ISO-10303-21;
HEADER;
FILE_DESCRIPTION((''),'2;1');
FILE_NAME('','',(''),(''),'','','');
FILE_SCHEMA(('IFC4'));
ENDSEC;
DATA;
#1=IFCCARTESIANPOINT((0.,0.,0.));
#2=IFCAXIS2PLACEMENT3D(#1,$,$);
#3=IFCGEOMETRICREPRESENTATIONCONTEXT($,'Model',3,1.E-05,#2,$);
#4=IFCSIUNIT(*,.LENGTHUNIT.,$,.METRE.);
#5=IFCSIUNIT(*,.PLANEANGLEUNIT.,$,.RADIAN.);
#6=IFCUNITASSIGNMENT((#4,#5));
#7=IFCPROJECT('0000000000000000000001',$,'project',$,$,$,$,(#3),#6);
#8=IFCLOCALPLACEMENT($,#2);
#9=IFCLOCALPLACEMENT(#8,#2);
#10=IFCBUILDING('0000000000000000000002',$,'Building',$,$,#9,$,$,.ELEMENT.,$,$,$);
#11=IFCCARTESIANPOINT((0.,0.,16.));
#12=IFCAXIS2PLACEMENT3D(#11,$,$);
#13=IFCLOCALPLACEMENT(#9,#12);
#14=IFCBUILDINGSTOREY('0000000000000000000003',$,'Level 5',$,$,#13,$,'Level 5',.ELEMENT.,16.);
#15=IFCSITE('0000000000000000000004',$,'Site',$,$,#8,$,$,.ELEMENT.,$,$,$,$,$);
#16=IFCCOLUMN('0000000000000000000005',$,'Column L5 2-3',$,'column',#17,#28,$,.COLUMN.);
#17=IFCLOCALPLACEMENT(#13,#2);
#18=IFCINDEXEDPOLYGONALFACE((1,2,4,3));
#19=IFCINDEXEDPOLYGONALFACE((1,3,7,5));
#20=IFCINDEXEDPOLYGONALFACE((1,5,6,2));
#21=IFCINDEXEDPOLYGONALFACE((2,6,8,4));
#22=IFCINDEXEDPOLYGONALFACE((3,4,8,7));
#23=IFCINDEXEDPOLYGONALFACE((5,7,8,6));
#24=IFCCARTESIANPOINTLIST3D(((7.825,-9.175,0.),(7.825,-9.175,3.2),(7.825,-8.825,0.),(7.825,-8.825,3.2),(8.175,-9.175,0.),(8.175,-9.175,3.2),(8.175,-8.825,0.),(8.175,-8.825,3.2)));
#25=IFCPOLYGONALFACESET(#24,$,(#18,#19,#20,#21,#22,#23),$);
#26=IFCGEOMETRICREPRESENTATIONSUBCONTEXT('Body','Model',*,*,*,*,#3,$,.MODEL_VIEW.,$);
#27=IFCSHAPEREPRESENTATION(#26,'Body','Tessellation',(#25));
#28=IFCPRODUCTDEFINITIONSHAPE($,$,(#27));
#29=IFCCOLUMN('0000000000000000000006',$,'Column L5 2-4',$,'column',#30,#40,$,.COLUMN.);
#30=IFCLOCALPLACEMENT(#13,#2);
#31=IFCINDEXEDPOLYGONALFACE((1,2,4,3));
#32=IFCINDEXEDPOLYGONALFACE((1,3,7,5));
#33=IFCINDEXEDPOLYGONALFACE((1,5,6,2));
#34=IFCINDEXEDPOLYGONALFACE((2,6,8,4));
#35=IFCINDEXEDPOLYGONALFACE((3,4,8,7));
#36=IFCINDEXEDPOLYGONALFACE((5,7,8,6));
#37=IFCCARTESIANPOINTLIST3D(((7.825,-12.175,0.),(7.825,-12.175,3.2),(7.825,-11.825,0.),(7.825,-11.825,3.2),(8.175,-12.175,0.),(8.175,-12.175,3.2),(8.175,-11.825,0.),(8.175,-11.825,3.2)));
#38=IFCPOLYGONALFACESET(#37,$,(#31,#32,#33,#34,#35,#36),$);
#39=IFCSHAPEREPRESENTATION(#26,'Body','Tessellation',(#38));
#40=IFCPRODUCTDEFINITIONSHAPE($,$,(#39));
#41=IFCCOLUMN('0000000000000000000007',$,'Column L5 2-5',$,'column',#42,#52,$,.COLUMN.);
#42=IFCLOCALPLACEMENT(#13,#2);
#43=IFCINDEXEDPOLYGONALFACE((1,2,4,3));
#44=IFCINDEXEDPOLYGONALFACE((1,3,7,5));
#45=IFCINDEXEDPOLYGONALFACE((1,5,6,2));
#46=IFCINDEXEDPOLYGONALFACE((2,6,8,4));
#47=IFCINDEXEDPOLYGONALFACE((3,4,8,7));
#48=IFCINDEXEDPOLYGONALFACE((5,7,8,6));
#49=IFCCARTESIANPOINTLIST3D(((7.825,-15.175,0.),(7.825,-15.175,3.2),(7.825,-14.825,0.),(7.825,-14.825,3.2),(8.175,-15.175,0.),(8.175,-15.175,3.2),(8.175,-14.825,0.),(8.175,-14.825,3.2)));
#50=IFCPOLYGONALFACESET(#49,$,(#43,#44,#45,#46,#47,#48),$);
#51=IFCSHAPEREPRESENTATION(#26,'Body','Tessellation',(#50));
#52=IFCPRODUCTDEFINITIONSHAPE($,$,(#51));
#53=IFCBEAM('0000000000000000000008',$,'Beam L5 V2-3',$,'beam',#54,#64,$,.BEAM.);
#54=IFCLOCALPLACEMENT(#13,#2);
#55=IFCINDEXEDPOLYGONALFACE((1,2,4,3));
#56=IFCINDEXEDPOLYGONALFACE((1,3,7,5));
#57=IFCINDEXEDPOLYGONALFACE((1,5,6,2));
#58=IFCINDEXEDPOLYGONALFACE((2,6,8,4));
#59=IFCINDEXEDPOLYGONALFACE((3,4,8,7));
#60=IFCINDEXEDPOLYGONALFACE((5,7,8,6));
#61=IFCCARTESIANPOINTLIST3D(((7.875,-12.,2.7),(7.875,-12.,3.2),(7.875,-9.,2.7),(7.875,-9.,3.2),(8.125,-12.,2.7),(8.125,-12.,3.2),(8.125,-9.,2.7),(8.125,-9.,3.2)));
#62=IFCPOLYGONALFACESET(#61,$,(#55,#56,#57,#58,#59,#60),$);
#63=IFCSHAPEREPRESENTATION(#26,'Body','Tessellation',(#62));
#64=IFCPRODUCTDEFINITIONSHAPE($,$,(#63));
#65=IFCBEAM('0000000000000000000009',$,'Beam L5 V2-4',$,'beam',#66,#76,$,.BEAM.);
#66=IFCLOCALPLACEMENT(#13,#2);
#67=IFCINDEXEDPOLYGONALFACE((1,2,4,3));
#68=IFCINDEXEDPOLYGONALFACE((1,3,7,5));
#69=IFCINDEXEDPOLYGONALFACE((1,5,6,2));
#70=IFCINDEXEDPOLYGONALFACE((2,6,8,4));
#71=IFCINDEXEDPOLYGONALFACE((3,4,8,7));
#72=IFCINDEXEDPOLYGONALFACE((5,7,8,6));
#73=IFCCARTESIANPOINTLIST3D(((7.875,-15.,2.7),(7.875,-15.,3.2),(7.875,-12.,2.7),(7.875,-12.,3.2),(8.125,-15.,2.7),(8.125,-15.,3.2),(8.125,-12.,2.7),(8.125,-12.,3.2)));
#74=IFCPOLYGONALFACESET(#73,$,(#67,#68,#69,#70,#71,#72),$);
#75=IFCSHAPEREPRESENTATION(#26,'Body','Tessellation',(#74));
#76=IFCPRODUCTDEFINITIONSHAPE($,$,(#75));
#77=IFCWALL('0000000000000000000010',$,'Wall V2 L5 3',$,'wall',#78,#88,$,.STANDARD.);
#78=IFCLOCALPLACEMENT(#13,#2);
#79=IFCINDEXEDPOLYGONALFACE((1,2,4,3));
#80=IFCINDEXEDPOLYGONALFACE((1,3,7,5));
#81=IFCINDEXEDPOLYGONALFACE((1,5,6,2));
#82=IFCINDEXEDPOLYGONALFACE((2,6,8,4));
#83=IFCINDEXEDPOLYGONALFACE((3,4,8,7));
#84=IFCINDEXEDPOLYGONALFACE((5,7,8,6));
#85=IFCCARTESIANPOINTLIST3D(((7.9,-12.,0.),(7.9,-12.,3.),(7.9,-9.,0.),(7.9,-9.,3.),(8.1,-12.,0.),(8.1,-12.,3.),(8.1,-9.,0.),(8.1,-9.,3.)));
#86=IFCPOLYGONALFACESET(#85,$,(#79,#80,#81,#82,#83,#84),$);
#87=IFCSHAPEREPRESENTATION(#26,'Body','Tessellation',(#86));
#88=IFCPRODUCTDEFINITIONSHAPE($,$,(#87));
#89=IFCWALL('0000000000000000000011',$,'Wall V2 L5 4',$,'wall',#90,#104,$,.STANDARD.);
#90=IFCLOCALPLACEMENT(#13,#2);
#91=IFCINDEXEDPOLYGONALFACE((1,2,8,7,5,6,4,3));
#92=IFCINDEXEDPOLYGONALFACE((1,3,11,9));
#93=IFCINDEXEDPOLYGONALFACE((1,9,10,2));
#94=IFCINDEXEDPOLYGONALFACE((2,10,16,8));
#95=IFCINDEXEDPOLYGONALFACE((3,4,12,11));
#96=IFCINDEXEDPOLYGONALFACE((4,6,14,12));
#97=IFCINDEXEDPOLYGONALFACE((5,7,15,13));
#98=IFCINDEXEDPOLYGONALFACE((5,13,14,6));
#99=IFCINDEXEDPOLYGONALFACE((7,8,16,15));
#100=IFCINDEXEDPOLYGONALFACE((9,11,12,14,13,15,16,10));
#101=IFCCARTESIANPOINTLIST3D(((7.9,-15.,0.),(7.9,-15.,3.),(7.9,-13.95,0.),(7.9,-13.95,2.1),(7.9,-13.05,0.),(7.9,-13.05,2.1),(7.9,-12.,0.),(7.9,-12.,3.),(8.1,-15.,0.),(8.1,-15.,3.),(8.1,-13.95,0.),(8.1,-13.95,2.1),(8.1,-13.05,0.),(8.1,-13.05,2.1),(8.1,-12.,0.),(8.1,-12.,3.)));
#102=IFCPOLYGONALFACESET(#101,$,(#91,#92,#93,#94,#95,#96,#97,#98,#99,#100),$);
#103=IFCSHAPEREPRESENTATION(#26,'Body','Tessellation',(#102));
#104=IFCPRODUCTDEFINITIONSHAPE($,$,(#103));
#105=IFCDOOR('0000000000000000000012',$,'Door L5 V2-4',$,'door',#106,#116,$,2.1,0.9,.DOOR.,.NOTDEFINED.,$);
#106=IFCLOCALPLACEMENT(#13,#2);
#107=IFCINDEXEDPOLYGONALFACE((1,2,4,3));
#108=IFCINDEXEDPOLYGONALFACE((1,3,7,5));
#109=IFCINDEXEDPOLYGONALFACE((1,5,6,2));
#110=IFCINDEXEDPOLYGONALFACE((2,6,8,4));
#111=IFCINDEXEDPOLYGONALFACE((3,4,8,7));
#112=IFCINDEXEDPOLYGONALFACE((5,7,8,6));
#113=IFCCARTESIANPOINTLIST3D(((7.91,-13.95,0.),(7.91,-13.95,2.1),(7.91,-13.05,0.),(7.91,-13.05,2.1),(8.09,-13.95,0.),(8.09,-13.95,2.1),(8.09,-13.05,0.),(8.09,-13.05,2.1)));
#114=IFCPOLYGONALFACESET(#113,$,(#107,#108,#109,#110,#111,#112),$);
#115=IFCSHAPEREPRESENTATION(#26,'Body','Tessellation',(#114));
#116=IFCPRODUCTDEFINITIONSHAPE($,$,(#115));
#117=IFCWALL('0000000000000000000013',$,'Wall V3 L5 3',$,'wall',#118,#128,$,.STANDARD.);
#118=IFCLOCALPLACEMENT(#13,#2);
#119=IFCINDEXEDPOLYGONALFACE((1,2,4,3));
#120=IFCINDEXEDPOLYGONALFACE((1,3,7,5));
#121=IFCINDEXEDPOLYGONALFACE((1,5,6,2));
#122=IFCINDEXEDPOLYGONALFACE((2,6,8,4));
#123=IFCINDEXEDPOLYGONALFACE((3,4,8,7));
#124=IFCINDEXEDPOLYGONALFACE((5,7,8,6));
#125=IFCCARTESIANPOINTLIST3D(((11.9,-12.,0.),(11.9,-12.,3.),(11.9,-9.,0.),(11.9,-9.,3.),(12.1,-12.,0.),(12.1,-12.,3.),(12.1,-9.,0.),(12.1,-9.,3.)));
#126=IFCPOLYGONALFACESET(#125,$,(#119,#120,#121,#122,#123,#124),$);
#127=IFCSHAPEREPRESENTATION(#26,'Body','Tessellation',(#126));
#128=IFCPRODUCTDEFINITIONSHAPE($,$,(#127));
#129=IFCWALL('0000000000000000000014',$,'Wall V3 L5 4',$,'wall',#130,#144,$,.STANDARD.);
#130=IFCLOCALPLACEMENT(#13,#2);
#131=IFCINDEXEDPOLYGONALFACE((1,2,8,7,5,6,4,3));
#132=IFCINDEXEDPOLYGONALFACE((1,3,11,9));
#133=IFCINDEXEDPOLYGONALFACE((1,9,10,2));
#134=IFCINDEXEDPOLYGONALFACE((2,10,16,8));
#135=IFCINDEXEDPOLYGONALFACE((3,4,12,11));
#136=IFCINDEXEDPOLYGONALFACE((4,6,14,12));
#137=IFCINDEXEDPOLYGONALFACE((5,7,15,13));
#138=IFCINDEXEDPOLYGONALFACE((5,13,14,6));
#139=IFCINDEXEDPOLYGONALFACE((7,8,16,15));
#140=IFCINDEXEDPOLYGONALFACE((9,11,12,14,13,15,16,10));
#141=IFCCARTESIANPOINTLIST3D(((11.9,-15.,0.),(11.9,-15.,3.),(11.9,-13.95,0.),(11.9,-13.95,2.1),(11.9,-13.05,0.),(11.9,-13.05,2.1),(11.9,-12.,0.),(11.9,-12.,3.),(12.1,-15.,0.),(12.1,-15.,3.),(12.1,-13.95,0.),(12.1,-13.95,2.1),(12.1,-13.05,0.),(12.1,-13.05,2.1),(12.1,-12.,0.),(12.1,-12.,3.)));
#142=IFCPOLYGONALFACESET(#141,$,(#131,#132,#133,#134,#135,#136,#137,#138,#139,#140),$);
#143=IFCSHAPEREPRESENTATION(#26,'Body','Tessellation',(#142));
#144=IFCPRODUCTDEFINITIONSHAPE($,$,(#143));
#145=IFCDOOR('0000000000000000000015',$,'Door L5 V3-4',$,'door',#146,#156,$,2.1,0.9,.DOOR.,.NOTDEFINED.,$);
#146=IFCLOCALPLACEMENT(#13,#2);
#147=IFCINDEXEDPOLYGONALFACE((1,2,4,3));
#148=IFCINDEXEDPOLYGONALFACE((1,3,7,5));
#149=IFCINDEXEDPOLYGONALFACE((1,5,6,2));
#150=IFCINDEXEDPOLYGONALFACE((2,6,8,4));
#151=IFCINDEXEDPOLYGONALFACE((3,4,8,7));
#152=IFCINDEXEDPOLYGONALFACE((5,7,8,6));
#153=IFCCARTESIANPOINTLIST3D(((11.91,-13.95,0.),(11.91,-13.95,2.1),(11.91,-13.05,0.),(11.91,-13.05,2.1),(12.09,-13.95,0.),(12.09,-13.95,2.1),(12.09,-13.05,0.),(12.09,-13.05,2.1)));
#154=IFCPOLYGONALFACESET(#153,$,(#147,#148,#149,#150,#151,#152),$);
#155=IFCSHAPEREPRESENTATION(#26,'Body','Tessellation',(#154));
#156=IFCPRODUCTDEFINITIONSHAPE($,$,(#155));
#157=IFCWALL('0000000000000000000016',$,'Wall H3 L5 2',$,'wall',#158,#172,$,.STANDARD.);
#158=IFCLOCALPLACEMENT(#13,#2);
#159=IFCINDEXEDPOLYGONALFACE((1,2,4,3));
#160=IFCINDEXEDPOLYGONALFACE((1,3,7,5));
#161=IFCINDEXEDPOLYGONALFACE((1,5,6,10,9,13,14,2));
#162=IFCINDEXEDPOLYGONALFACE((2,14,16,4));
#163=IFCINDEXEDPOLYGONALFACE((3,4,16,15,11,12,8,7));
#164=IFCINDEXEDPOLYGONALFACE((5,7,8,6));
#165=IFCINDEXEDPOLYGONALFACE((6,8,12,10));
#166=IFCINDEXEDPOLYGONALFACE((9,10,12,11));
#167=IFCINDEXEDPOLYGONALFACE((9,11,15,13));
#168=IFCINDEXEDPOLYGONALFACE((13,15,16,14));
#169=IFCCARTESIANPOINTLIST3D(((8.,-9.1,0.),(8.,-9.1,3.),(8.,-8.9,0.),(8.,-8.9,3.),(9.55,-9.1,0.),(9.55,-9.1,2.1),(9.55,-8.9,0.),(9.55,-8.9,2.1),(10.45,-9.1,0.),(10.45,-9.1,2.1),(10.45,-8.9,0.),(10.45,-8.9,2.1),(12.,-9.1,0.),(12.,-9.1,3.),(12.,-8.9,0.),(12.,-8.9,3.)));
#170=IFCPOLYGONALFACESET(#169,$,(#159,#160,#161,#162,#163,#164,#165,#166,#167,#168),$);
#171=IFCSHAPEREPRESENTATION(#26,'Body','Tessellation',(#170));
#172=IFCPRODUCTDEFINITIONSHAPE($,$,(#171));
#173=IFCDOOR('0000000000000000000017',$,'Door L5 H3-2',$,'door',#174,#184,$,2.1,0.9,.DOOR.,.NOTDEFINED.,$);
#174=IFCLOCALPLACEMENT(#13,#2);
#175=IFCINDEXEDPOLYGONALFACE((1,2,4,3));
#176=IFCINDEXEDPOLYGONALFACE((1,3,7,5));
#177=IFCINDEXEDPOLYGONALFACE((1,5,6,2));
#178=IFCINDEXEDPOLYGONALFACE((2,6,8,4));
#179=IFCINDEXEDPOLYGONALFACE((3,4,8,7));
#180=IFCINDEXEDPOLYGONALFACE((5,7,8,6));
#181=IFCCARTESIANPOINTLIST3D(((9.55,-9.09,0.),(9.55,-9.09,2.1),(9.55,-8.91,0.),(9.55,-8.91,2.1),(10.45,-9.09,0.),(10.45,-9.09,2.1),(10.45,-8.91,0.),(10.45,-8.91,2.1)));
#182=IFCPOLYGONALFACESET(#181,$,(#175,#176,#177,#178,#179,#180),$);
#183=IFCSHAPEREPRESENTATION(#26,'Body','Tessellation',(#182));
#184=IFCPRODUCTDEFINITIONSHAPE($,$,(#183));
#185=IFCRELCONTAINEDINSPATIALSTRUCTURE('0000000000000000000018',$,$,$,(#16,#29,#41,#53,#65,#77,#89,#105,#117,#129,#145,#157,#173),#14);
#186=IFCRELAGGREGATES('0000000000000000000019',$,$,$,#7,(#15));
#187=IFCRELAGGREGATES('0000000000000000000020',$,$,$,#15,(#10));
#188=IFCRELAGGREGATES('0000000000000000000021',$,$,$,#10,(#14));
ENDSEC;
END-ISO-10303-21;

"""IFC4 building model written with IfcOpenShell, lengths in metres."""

from ifc_helpers import new_model, si_unit, frame, frame_2d, origin, origin_2d, place, context, subcontext, project, spatial, rectangle, extrude, element, fill, save


model = new_model("IFC4")

# Units and contexts
model_context = context("Model", 3, precision=1e-05, world=origin())
body_context = subcontext(model_context, "Body", "Model", "MODEL_VIEW")
ifc_project = project(units=[si_unit("LENGTHUNIT", "METRE"), si_unit("PLANEANGLEUNIT", "RADIAN")], contexts=[model_context])

# Site, building, storey
site_placement = place(None, origin())
site = spatial("IfcSite", under=ifc_project, at=site_placement, Name="Site", CompositionType="ELEMENT")
building_placement = place(site_placement, origin())
building = spatial("IfcBuilding", under=site, at=building_placement, Name="Building", CompositionType="ELEMENT")
storey_placement = place(building_placement, frame((0.0, 0.0, 16.0)))
storey = spatial("IfcBuildingStorey", under=building, at=storey_placement, Name="Level 5", LongName="Level 5", CompositionType="ELEMENT", Elevation=16.0)

# Columns
for number, where, name in (
    (1, (8.0, -9.0, 0.0), "Column L5 2-3"),
    (2, (8.0, -12.0, 0.0), "Column L5 2-4"),
    (3, (8.0, -15.0, 0.0), "Column L5 2-5"),
):
    element("IfcColumn", number, at=place(storey_placement, frame(where)), inside=storey, Name=name, ObjectType="column", PredefinedType="COLUMN", context=body_context, shape_type="SweptSolid", body=[
        extrude(rectangle(XDim=0.35, YDim=0.35, at=origin_2d()), origin(), (0.0, 0.0, 1.0), 3.2),
    ])

# Beams
for number, where, z_axis, x_axis, name in (
    (4, (8.0, -9.0, 2.95), (0.0, -1.0, 0.0), (0.0, 0.0, 1.0), "Beam L5 V2-3"),
    (5, (8.0, -12.0, 2.95), (0.0, -1.0, 0.0), (0.0, 0.0, 1.0), "Beam L5 V2-4"),
):
    element("IfcBeam", number, at=place(storey_placement, frame(where, z_axis=z_axis, x_axis=x_axis)), inside=storey, Name=name, ObjectType="beam", PredefinedType="BEAM", context=body_context, shape_type="SweptSolid", body=[
        extrude(rectangle(XDim=0.5, YDim=0.25, at=origin_2d()), origin(), (0.0, 0.0, 1.0), 3.0),
    ])

# Wall
wall_1_placement = place(storey_placement, frame((8.0, -9.0, 0.0), z_axis=(0.0, 0.0, 1.0), x_axis=(0.0, -1.0, 0.0)))
element("IfcWall", 6, at=wall_1_placement, inside=storey, Name="Wall V2 L5 3", ObjectType="wall", PredefinedType="STANDARD", context=body_context, shape_type="SweptSolid", body=[
    extrude(rectangle(XDim=3.0, YDim=0.2, at=frame_2d((1.5, 0.0))), origin(), (0.0, 0.0, 1.0), 3.0),
])

# Wall, opening, door
wall_2_placement = place(storey_placement, frame((8.0, -12.0, 0.0), z_axis=(0.0, 0.0, 1.0), x_axis=(0.0, -1.0, 0.0)))
wall_2 = element("IfcWall", 7, at=wall_2_placement, inside=storey, Name="Wall V2 L5 4", ObjectType="wall", PredefinedType="STANDARD", context=body_context, shape_type="SweptSolid", body=[
    extrude(rectangle(XDim=3.0, YDim=0.2, at=frame_2d((1.5, 0.0))), origin(), (0.0, 0.0, 1.0), 3.0),
])
opening_1_placement = place(storey_placement, frame((8.0, -13.5, 0.0), z_axis=(0.0, 0.0, 1.0), x_axis=(0.0, -1.0, 0.0)))
opening_1 = element("IfcOpeningElement", 8, at=opening_1_placement, cuts=wall_2, ObjectType="Opening", PredefinedType="OPENING", context=body_context, shape_type="SweptSolid", body=[
    extrude(rectangle(XDim=0.9, YDim=0.22, at=origin_2d()), origin(), (0.0, 0.0, 1.0), 2.1),
])
door_1_placement = place(storey_placement, frame((8.0, -13.5, 0.0), z_axis=(0.0, 0.0, 1.0), x_axis=(0.0, -1.0, 0.0)))
door_1 = element("IfcDoor", 9, at=door_1_placement, inside=storey, Name="Door L5 V2-4", ObjectType="door", OperationType="NOTDEFINED", OverallHeight=2.1, OverallWidth=0.9, PredefinedType="DOOR", context=body_context, shape_type="SweptSolid", body=[
    extrude(rectangle(XDim=0.9, YDim=0.18, at=origin_2d()), origin(), (0.0, 0.0, 1.0), 2.1),
])
fill(opening_1, door_1)

# Wall
wall_3_placement = place(storey_placement, frame((12.0, -9.0, 0.0), z_axis=(0.0, 0.0, 1.0), x_axis=(0.0, -1.0, 0.0)))
element("IfcWall", 10, at=wall_3_placement, inside=storey, Name="Wall V3 L5 3", ObjectType="wall", PredefinedType="STANDARD", context=body_context, shape_type="SweptSolid", body=[
    extrude(rectangle(XDim=3.0, YDim=0.2, at=frame_2d((1.5, 0.0))), origin(), (0.0, 0.0, 1.0), 3.0),
])

# Walls, openings, doors
wall_4_placement = place(storey_placement, frame((12.0, -12.0, 0.0), z_axis=(0.0, 0.0, 1.0), x_axis=(0.0, -1.0, 0.0)))
wall_4 = element("IfcWall", 11, at=wall_4_placement, inside=storey, Name="Wall V3 L5 4", ObjectType="wall", PredefinedType="STANDARD", context=body_context, shape_type="SweptSolid", body=[
    extrude(rectangle(XDim=3.0, YDim=0.2, at=frame_2d((1.5, 0.0))), origin(), (0.0, 0.0, 1.0), 3.0),
])
opening_2_placement = place(storey_placement, frame((12.0, -13.5, 0.0), z_axis=(0.0, 0.0, 1.0), x_axis=(0.0, -1.0, 0.0)))
opening_2 = element("IfcOpeningElement", 12, at=opening_2_placement, cuts=wall_4, ObjectType="Opening", PredefinedType="OPENING", context=body_context, shape_type="SweptSolid", body=[
    extrude(rectangle(XDim=0.9, YDim=0.22, at=origin_2d()), origin(), (0.0, 0.0, 1.0), 2.1),
])
door_2_placement = place(storey_placement, frame((12.0, -13.5, 0.0), z_axis=(0.0, 0.0, 1.0), x_axis=(0.0, -1.0, 0.0)))
door_2 = element("IfcDoor", 13, at=door_2_placement, inside=storey, Name="Door L5 V3-4", ObjectType="door", OperationType="NOTDEFINED", OverallHeight=2.1, OverallWidth=0.9, PredefinedType="DOOR", context=body_context, shape_type="SweptSolid", body=[
    extrude(rectangle(XDim=0.9, YDim=0.18, at=origin_2d()), origin(), (0.0, 0.0, 1.0), 2.1),
])
fill(opening_2, door_2)
wall_5_placement = place(storey_placement, frame((8.0, -9.0, 0.0), z_axis=(0.0, 0.0, 1.0), x_axis=(1.0, 0.0, 0.0)))
wall_5 = element("IfcWall", 14, at=wall_5_placement, inside=storey, Name="Wall H3 L5 2", ObjectType="wall", PredefinedType="STANDARD", context=body_context, shape_type="SweptSolid", body=[
    extrude(rectangle(XDim=4.0, YDim=0.2, at=frame_2d((2.0, 0.0))), origin(), (0.0, 0.0, 1.0), 3.0),
])
opening_3_placement = place(storey_placement, frame((10.0, -9.0, 0.0), z_axis=(0.0, 0.0, 1.0), x_axis=(1.0, 0.0, 0.0)))
opening_3 = element("IfcOpeningElement", 15, at=opening_3_placement, cuts=wall_5, ObjectType="Opening", PredefinedType="OPENING", context=body_context, shape_type="SweptSolid", body=[
    extrude(rectangle(XDim=0.9, YDim=0.22, at=origin_2d()), origin(), (0.0, 0.0, 1.0), 2.1),
])
door_3_placement = place(storey_placement, frame((10.0, -9.0, 0.0), z_axis=(0.0, 0.0, 1.0), x_axis=(1.0, 0.0, 0.0)))
door_3 = element("IfcDoor", 16, at=door_3_placement, inside=storey, Name="Door L5 H3-2", ObjectType="door", OperationType="NOTDEFINED", OverallHeight=2.1, OverallWidth=0.9, PredefinedType="DOOR", context=body_context, shape_type="SweptSolid", body=[
    extrude(rectangle(XDim=0.9, YDim=0.18, at=origin_2d()), origin(), (0.0, 0.0, 1.0), 2.1),
])
fill(opening_3, door_3)

save(model, "model.ifc")
